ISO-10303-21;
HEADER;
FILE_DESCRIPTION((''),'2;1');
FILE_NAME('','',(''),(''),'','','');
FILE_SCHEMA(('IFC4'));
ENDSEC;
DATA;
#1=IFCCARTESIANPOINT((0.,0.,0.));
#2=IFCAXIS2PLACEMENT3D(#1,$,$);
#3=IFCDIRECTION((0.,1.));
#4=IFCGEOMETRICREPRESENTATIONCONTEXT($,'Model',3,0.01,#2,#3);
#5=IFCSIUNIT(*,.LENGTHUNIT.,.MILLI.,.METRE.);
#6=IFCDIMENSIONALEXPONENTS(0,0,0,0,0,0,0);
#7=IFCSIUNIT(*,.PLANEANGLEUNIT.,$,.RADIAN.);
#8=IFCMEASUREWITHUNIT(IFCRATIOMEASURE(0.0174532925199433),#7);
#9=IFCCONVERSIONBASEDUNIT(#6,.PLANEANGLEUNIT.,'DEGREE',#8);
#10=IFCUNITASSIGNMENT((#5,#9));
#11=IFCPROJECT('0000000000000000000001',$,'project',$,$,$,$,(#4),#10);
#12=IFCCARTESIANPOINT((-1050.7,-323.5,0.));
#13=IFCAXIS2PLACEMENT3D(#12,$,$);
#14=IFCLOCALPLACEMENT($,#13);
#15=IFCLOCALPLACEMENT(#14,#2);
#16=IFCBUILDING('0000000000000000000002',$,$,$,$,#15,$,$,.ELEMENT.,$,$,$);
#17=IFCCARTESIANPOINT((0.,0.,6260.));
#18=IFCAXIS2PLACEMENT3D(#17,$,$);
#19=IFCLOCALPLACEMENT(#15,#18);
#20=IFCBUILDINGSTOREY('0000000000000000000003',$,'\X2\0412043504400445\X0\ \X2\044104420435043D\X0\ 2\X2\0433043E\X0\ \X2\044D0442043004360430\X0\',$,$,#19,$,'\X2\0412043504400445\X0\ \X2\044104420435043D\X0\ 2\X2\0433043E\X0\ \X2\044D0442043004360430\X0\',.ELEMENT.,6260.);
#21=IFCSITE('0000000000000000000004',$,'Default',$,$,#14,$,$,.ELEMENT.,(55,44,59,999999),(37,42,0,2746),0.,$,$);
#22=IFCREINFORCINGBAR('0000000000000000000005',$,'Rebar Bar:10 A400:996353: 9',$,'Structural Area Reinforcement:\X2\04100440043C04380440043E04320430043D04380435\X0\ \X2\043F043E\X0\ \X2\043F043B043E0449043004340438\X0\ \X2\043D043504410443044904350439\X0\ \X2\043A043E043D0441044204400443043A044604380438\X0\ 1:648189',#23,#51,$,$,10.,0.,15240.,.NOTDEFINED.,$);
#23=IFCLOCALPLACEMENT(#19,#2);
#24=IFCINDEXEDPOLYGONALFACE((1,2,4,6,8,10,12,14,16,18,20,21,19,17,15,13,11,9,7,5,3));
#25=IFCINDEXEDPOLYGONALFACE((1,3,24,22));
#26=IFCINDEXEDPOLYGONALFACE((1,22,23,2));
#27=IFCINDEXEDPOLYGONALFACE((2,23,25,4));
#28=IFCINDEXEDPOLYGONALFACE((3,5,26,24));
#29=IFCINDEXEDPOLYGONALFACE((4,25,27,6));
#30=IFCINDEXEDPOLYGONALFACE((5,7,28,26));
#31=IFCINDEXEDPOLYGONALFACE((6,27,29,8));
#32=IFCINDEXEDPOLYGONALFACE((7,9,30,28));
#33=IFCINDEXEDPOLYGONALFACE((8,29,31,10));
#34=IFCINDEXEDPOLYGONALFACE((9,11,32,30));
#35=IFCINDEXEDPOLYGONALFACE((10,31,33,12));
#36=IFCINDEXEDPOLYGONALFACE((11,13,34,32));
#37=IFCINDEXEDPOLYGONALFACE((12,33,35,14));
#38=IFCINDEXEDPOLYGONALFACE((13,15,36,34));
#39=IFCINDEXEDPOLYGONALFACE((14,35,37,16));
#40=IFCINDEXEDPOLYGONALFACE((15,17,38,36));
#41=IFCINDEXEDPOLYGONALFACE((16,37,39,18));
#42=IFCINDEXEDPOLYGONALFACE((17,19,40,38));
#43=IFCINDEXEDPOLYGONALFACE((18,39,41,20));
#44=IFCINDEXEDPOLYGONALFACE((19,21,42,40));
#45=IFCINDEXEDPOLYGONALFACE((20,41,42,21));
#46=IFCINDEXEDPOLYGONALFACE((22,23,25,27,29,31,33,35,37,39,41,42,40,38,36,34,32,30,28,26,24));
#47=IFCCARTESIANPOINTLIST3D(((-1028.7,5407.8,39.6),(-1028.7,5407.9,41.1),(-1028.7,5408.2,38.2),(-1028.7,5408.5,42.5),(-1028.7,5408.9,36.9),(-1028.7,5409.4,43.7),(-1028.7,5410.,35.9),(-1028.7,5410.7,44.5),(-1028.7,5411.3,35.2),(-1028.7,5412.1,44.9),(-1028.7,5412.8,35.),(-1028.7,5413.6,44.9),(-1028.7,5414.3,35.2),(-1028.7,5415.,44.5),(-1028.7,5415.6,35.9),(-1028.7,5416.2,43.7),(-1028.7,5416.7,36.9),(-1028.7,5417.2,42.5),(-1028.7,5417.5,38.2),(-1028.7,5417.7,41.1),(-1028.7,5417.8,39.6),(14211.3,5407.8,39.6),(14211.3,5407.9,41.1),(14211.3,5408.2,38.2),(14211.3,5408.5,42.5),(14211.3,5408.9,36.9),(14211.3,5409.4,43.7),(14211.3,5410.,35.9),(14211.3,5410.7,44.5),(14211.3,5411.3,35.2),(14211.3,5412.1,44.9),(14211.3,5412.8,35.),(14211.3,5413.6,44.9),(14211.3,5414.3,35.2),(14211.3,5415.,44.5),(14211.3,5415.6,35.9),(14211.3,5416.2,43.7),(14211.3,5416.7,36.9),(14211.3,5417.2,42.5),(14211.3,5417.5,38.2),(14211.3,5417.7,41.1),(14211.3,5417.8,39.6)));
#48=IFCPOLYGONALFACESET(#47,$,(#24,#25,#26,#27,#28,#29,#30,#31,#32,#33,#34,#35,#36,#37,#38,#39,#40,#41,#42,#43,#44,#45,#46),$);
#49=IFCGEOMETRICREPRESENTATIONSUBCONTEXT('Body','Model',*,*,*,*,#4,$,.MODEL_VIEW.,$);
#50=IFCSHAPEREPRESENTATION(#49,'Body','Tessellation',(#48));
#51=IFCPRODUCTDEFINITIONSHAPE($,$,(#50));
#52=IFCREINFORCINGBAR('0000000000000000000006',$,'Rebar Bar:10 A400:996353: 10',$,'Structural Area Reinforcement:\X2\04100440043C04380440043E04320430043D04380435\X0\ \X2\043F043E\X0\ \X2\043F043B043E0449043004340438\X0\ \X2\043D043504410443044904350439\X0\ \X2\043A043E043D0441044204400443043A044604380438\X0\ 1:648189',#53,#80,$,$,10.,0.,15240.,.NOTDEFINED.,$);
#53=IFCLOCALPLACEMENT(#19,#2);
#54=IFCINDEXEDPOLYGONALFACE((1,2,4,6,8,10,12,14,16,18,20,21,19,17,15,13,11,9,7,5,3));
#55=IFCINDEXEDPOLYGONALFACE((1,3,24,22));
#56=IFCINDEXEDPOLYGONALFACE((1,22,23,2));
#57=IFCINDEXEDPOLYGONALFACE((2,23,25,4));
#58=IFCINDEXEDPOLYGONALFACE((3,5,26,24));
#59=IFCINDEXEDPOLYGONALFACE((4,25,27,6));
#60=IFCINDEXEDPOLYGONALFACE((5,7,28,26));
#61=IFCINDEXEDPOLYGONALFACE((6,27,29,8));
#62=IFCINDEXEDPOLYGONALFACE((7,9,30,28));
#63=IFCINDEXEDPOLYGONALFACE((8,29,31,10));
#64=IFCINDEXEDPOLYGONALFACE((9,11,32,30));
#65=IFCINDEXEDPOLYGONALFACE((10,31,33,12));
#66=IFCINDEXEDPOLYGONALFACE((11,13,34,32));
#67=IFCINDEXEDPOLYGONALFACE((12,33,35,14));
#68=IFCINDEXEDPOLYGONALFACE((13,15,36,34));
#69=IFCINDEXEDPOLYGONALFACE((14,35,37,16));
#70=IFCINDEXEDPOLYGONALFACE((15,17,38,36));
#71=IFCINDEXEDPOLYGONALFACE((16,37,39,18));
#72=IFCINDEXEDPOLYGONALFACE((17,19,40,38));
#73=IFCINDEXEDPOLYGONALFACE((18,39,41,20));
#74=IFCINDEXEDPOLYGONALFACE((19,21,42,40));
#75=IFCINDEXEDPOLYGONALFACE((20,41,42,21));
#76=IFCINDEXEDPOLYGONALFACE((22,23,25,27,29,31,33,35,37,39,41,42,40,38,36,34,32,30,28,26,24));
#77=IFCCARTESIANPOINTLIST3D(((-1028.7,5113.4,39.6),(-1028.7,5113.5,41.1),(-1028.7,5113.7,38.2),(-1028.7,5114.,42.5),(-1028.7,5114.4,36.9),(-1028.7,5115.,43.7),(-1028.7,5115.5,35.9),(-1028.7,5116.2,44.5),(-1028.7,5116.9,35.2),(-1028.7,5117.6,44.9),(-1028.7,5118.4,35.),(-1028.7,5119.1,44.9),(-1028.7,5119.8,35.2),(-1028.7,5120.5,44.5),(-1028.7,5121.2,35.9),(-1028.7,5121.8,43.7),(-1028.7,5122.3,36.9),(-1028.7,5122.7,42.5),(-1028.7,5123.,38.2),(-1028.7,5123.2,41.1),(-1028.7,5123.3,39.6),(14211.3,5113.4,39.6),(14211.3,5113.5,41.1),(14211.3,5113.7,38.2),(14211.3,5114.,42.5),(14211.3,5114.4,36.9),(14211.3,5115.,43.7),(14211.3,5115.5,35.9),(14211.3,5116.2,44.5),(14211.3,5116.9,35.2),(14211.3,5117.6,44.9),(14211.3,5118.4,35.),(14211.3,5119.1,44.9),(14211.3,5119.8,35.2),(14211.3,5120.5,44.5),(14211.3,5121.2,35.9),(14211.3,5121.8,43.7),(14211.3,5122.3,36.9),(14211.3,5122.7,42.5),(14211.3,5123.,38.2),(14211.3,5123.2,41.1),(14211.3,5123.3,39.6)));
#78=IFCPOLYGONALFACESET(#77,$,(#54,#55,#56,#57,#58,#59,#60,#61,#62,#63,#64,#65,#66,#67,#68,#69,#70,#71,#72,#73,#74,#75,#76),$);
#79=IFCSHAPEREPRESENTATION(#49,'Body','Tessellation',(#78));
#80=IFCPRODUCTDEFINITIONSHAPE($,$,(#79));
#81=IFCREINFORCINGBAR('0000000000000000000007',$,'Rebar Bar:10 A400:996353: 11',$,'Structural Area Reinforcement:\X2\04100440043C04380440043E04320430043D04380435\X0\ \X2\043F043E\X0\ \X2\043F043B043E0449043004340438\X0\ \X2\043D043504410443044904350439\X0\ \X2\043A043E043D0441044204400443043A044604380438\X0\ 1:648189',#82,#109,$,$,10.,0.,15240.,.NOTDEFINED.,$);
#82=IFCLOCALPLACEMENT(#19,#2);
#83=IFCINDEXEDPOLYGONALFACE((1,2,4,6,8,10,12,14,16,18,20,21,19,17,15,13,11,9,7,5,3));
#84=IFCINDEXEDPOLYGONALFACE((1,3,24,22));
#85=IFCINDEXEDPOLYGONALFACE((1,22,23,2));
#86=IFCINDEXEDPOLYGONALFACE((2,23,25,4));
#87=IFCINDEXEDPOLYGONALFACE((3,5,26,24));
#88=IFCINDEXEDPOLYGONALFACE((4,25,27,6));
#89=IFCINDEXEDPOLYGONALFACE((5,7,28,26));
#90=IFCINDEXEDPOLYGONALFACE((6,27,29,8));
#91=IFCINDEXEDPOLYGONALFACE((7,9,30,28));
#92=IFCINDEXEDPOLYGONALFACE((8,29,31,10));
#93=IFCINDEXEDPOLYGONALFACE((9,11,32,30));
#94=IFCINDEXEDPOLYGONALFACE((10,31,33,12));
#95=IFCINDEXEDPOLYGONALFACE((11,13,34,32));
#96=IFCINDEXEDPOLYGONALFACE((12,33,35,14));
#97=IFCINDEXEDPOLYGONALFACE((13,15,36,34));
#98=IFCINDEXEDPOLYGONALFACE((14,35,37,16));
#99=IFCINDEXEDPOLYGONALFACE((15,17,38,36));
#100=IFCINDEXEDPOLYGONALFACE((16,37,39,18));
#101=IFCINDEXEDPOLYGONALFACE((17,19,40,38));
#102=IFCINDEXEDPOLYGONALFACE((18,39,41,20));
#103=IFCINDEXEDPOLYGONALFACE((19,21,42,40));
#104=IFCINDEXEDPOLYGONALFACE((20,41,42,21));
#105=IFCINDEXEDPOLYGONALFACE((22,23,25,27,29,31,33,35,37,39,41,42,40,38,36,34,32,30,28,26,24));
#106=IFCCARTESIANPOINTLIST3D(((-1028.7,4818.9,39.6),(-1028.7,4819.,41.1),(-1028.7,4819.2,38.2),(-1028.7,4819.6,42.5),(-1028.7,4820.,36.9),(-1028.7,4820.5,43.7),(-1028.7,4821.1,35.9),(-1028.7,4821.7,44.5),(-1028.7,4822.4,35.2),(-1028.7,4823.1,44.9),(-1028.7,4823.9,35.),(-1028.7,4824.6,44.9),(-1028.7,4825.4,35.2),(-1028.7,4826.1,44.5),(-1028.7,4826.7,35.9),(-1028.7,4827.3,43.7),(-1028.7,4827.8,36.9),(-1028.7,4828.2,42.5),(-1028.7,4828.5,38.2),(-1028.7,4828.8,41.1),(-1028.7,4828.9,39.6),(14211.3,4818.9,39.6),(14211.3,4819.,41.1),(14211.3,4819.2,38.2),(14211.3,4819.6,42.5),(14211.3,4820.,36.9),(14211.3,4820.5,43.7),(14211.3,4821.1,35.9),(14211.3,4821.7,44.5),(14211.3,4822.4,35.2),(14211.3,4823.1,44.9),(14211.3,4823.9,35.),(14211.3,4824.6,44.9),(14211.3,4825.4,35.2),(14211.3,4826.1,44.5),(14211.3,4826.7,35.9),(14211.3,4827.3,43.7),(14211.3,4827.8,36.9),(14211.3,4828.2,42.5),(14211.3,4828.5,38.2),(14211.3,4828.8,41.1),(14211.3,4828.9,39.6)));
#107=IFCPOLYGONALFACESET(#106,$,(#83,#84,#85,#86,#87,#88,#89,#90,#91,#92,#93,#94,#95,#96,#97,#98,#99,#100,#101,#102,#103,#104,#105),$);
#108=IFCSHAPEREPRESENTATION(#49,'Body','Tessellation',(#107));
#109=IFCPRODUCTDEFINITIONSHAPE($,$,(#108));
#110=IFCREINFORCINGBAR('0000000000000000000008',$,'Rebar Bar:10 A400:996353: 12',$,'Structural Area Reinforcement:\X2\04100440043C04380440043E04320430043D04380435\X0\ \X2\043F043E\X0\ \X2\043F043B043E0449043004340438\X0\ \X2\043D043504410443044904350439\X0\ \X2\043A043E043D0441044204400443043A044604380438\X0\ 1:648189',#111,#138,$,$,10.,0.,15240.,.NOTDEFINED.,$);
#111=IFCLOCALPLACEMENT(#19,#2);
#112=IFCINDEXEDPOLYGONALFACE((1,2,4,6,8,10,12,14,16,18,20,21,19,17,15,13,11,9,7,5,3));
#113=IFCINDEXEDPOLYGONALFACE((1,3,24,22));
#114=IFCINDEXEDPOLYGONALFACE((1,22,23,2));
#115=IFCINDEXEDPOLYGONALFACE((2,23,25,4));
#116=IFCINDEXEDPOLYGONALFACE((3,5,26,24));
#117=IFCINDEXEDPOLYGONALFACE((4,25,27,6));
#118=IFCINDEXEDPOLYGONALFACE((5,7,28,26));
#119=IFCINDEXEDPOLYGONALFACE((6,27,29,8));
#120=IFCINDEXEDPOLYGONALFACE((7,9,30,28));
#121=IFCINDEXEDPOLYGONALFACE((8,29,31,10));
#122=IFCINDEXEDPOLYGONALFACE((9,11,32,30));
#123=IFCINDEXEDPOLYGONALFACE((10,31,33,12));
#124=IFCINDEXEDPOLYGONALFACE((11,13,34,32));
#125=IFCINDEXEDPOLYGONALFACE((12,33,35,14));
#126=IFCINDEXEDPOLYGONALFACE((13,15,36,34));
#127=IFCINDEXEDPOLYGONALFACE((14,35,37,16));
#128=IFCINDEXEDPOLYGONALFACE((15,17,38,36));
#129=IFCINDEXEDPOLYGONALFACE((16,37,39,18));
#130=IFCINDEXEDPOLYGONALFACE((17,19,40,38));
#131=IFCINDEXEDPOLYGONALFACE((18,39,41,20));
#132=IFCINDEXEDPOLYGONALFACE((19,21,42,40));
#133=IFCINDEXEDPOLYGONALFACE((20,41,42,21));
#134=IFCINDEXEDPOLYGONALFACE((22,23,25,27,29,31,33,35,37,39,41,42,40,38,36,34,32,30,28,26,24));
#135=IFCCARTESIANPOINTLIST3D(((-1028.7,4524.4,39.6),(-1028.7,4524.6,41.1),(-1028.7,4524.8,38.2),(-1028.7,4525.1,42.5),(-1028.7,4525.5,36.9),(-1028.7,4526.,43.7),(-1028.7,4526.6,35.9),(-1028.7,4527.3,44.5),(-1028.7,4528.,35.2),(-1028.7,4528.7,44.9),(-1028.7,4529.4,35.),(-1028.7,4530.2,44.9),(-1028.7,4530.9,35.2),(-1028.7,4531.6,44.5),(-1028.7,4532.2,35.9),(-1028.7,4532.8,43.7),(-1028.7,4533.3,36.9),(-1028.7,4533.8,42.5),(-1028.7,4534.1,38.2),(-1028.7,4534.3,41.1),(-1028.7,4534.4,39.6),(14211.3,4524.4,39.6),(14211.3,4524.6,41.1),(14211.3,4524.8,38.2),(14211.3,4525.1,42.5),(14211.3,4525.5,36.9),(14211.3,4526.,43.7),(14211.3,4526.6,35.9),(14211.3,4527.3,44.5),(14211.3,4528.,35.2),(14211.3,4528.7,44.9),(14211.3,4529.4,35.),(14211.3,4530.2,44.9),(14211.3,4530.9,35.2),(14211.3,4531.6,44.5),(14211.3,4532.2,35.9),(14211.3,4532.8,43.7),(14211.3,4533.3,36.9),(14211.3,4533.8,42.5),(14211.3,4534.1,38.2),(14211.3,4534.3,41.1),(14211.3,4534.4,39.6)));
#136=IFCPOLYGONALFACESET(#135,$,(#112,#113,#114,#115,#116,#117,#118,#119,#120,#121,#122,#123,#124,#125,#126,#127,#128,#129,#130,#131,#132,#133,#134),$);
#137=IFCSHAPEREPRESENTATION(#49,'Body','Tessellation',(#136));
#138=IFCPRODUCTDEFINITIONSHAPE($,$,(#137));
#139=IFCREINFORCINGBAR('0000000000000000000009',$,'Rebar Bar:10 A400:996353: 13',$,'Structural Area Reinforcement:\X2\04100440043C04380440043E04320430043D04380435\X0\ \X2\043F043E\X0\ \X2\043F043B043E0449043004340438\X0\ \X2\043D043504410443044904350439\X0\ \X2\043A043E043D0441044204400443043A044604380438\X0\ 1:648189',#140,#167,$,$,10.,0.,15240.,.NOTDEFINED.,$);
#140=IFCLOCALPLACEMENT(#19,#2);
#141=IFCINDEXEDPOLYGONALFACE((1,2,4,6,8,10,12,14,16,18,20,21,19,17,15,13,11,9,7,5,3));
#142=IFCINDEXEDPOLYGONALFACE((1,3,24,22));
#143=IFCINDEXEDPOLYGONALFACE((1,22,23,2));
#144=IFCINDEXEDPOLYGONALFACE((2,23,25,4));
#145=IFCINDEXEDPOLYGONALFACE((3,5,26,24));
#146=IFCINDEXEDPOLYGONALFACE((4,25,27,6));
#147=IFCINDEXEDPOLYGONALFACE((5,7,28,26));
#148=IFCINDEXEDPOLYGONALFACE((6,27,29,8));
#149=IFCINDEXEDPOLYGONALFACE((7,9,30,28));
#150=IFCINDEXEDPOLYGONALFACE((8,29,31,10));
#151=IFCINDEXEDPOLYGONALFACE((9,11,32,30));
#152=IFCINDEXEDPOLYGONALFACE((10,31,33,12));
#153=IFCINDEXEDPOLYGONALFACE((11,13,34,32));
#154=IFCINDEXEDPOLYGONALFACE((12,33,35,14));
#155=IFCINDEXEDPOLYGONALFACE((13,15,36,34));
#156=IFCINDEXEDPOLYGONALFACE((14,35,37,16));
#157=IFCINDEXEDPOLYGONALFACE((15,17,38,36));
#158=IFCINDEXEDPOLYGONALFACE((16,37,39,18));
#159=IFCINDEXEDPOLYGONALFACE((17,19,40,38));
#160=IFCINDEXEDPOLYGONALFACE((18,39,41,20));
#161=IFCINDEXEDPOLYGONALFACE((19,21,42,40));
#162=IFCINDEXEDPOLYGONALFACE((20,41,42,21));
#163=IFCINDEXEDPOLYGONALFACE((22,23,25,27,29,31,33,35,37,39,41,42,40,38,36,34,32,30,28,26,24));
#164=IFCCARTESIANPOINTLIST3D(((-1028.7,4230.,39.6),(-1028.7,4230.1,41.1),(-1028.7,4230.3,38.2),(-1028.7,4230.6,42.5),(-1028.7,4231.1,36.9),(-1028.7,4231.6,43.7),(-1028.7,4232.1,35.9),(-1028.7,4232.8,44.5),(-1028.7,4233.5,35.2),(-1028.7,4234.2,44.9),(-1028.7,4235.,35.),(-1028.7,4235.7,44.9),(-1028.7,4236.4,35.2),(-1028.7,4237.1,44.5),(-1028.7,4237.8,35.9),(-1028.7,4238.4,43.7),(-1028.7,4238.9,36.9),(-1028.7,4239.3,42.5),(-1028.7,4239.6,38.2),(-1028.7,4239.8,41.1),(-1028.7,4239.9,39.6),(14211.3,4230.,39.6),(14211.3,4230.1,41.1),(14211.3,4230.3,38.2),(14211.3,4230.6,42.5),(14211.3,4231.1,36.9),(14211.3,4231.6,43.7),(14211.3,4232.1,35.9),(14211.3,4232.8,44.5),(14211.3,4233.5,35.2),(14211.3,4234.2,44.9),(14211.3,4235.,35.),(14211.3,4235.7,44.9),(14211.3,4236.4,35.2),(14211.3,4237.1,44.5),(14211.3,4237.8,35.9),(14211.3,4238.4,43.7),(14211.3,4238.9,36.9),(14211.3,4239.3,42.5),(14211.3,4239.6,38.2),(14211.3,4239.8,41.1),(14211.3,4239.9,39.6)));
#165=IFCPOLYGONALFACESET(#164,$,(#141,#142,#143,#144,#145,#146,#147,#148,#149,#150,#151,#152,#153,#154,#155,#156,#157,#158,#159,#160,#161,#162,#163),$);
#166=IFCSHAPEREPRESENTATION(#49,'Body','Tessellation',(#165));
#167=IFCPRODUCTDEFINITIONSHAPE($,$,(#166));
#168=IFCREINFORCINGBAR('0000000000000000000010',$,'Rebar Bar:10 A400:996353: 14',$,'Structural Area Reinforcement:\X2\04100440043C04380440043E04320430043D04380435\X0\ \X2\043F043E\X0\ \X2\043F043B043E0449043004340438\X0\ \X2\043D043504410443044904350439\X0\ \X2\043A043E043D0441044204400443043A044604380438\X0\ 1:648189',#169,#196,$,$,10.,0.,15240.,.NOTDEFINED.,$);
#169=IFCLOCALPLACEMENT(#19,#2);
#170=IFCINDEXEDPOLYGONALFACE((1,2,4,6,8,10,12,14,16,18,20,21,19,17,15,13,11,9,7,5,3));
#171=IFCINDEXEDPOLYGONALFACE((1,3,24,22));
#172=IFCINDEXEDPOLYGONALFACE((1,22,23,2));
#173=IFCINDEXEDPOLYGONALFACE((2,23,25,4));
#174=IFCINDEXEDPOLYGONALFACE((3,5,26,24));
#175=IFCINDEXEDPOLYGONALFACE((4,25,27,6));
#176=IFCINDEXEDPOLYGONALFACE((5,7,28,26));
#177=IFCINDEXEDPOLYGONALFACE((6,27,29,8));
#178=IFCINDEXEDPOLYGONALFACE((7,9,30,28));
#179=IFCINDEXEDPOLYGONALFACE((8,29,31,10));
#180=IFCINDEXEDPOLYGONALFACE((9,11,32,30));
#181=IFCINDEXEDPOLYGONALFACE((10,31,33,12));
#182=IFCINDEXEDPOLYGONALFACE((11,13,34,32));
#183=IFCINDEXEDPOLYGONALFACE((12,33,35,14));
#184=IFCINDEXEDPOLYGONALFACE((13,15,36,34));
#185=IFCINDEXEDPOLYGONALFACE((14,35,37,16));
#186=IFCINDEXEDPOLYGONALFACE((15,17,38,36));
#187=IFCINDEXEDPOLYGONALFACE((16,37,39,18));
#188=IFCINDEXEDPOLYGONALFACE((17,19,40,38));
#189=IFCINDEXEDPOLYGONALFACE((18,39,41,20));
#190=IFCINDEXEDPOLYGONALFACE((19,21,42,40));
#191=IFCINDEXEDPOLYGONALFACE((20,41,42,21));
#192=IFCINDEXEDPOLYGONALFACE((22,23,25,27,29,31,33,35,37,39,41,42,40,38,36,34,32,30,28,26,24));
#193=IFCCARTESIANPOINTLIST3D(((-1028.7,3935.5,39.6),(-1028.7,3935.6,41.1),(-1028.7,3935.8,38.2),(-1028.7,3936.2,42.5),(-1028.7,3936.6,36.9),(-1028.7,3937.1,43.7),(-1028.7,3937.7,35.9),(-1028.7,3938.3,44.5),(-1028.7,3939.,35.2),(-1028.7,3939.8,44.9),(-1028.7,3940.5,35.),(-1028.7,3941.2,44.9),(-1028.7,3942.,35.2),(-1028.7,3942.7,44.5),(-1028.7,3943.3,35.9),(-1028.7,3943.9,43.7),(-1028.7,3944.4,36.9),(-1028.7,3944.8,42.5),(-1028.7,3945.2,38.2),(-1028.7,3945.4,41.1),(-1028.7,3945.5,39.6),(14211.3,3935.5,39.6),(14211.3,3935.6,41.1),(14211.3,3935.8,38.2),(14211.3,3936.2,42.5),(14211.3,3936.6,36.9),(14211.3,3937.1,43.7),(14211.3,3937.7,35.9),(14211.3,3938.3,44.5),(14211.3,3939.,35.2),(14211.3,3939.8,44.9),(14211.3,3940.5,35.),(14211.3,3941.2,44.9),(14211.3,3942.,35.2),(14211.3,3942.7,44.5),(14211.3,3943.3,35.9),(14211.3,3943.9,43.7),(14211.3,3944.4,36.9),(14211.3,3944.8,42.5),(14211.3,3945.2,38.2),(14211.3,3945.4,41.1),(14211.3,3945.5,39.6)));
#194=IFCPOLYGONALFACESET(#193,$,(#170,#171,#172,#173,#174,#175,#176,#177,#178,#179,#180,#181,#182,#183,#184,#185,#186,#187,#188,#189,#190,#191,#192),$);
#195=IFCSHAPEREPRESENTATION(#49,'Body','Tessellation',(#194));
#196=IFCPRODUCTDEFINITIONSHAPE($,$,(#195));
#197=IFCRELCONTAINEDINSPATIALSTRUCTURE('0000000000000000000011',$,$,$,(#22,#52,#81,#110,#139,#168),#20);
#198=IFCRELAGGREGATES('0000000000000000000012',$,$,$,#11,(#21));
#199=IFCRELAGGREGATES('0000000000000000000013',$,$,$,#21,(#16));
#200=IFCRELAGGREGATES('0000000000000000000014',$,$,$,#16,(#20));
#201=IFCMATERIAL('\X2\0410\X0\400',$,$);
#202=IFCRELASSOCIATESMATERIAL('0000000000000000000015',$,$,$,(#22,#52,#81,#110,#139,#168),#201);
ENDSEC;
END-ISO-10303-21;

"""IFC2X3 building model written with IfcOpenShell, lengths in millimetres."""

from ifc_helpers import new_model, entity, si_unit, converted_unit, direction, frame, origin, place, context, subcontext, project, spatial, material, element, save


model = new_model("IFC2X3")

# Units and contexts
model_context = context("Model", 3, precision=0.01, world=origin(), true_north=direction((0.0, 1.0)))
body_context = subcontext(model_context, "Body", "Model", "MODEL_VIEW")
ifc_project = project(units=[si_unit("LENGTHUNIT", "METRE", prefix="MILLI"), converted_unit("PLANEANGLEUNIT", "DEGREE", entity("IfcRatioMeasure", 0.0174532925199433), si_unit("PLANEANGLEUNIT", "RADIAN"), dimensions=[0, 0, 0, 0, 0, 0, 0])], contexts=[model_context])

# Site, building, storey
site_placement = place(None, frame((-1050.7, -323.5, 0.0)))
site = spatial("IfcSite", under=ifc_project, at=site_placement, Name="Default", CompositionType="ELEMENT", RefLatitude=(55, 44, 59, 999999), RefLongitude=(37, 42, 0, 2746), RefElevation=0.0)
building_placement = place(site_placement, origin())
building = spatial("IfcBuilding", under=site, at=building_placement, CompositionType="ELEMENT")
storey_placement = place(building_placement, frame((0.0, 0.0, 6260.0)))
storey = spatial("IfcBuildingStorey", under=building, at=storey_placement, Name="Верх стен 2го этажа", LongName="Верх стен 2го этажа", CompositionType="ELEMENT", Elevation=6260.0)

# Reinforcing bars
ifc_material = material(Name="А400")
reinforcing_bar_1_placement = place(storey_placement, origin())
element("IfcReinforcingBar", 1, at=reinforcing_bar_1_placement, inside=storey, material=ifc_material, Name="Rebar Bar:10 A400:996353: 9", ObjectType="Structural Area Reinforcement:Армирование по площади несущей конструкции 1:648189", BarLength=15240.0, BarRole="NOTDEFINED", CrossSectionArea=0.0, NominalDiameter=10.0, context=body_context, shape_type="AdvancedSweptSolid", body=[
    entity("IfcSweptDiskSolid", entity("IfcCompositeCurve", [entity("IfcCompositeCurveSegment", "CONTINUOUS", True, entity("IfcPolyline", [entity("IfcCartesianPoint", [14211.3, 5412.8, 40.0]), entity("IfcCartesianPoint", [-1028.7, 5412.8, 40.0])]))], False), 5.0, None, 0.0, 1.0),
])
reinforcing_bar_2_placement = place(storey_placement, origin())
element("IfcReinforcingBar", 2, at=reinforcing_bar_2_placement, inside=storey, material=ifc_material, Name="Rebar Bar:10 A400:996353: 10", ObjectType="Structural Area Reinforcement:Армирование по площади несущей конструкции 1:648189", BarLength=15240.0, BarRole="NOTDEFINED", CrossSectionArea=0.0, NominalDiameter=10.0, context=body_context, shape_type="AdvancedSweptSolid", body=[
    entity("IfcSweptDiskSolid", entity("IfcCompositeCurve", [entity("IfcCompositeCurveSegment", "CONTINUOUS", True, entity("IfcPolyline", [entity("IfcCartesianPoint", [14211.3, 5118.4, 40.0]), entity("IfcCartesianPoint", [-1028.7, 5118.4, 40.0])]))], False), 5.0, None, 0.0, 1.0),
])
reinforcing_bar_3_placement = place(storey_placement, origin())
element("IfcReinforcingBar", 3, at=reinforcing_bar_3_placement, inside=storey, material=ifc_material, Name="Rebar Bar:10 A400:996353: 11", ObjectType="Structural Area Reinforcement:Армирование по площади несущей конструкции 1:648189", BarLength=15240.0, BarRole="NOTDEFINED", CrossSectionArea=0.0, NominalDiameter=10.0, context=body_context, shape_type="AdvancedSweptSolid", body=[
    entity("IfcSweptDiskSolid", entity("IfcCompositeCurve", [entity("IfcCompositeCurveSegment", "CONTINUOUS", True, entity("IfcPolyline", [entity("IfcCartesianPoint", [14211.3, 4823.9, 40.0]), entity("IfcCartesianPoint", [-1028.7, 4823.9, 40.0])]))], False), 5.0, None, 0.0, 1.0),
])
reinforcing_bar_4_placement = place(storey_placement, origin())
element("IfcReinforcingBar", 4, at=reinforcing_bar_4_placement, inside=storey, material=ifc_material, Name="Rebar Bar:10 A400:996353: 12", ObjectType="Structural Area Reinforcement:Армирование по площади несущей конструкции 1:648189", BarLength=15240.0, BarRole="NOTDEFINED", CrossSectionArea=0.0, NominalDiameter=10.0, context=body_context, shape_type="AdvancedSweptSolid", body=[
    entity("IfcSweptDiskSolid", entity("IfcCompositeCurve", [entity("IfcCompositeCurveSegment", "CONTINUOUS", True, entity("IfcPolyline", [entity("IfcCartesianPoint", [14211.3, 4529.4, 40.0]), entity("IfcCartesianPoint", [-1028.7, 4529.4, 40.0])]))], False), 5.0, None, 0.0, 1.0),
])
reinforcing_bar_5_placement = place(storey_placement, origin())
element("IfcReinforcingBar", 5, at=reinforcing_bar_5_placement, inside=storey, material=ifc_material, Name="Rebar Bar:10 A400:996353: 13", ObjectType="Structural Area Reinforcement:Армирование по площади несущей конструкции 1:648189", BarLength=15240.0, BarRole="NOTDEFINED", CrossSectionArea=0.0, NominalDiameter=10.0, context=body_context, shape_type="AdvancedSweptSolid", body=[
    entity("IfcSweptDiskSolid", entity("IfcCompositeCurve", [entity("IfcCompositeCurveSegment", "CONTINUOUS", True, entity("IfcPolyline", [entity("IfcCartesianPoint", [14211.3, 4235.0, 40.0]), entity("IfcCartesianPoint", [-1028.7, 4235.0, 40.0])]))], False), 5.0, None, 0.0, 1.0),
])
reinforcing_bar_6_placement = place(storey_placement, origin())
element("IfcReinforcingBar", 6, at=reinforcing_bar_6_placement, inside=storey, material=ifc_material, Name="Rebar Bar:10 A400:996353: 14", ObjectType="Structural Area Reinforcement:Армирование по площади несущей конструкции 1:648189", BarLength=15240.0, BarRole="NOTDEFINED", CrossSectionArea=0.0, NominalDiameter=10.0, context=body_context, shape_type="AdvancedSweptSolid", body=[
    entity("IfcSweptDiskSolid", entity("IfcCompositeCurve", [entity("IfcCompositeCurveSegment", "CONTINUOUS", True, entity("IfcPolyline", [entity("IfcCartesianPoint", [14211.3, 3940.5, 40.0]), entity("IfcCartesianPoint", [-1028.7, 3940.5, 40.0])]))], False), 5.0, None, 0.0, 1.0),
])

save(model, "model.ifc")
